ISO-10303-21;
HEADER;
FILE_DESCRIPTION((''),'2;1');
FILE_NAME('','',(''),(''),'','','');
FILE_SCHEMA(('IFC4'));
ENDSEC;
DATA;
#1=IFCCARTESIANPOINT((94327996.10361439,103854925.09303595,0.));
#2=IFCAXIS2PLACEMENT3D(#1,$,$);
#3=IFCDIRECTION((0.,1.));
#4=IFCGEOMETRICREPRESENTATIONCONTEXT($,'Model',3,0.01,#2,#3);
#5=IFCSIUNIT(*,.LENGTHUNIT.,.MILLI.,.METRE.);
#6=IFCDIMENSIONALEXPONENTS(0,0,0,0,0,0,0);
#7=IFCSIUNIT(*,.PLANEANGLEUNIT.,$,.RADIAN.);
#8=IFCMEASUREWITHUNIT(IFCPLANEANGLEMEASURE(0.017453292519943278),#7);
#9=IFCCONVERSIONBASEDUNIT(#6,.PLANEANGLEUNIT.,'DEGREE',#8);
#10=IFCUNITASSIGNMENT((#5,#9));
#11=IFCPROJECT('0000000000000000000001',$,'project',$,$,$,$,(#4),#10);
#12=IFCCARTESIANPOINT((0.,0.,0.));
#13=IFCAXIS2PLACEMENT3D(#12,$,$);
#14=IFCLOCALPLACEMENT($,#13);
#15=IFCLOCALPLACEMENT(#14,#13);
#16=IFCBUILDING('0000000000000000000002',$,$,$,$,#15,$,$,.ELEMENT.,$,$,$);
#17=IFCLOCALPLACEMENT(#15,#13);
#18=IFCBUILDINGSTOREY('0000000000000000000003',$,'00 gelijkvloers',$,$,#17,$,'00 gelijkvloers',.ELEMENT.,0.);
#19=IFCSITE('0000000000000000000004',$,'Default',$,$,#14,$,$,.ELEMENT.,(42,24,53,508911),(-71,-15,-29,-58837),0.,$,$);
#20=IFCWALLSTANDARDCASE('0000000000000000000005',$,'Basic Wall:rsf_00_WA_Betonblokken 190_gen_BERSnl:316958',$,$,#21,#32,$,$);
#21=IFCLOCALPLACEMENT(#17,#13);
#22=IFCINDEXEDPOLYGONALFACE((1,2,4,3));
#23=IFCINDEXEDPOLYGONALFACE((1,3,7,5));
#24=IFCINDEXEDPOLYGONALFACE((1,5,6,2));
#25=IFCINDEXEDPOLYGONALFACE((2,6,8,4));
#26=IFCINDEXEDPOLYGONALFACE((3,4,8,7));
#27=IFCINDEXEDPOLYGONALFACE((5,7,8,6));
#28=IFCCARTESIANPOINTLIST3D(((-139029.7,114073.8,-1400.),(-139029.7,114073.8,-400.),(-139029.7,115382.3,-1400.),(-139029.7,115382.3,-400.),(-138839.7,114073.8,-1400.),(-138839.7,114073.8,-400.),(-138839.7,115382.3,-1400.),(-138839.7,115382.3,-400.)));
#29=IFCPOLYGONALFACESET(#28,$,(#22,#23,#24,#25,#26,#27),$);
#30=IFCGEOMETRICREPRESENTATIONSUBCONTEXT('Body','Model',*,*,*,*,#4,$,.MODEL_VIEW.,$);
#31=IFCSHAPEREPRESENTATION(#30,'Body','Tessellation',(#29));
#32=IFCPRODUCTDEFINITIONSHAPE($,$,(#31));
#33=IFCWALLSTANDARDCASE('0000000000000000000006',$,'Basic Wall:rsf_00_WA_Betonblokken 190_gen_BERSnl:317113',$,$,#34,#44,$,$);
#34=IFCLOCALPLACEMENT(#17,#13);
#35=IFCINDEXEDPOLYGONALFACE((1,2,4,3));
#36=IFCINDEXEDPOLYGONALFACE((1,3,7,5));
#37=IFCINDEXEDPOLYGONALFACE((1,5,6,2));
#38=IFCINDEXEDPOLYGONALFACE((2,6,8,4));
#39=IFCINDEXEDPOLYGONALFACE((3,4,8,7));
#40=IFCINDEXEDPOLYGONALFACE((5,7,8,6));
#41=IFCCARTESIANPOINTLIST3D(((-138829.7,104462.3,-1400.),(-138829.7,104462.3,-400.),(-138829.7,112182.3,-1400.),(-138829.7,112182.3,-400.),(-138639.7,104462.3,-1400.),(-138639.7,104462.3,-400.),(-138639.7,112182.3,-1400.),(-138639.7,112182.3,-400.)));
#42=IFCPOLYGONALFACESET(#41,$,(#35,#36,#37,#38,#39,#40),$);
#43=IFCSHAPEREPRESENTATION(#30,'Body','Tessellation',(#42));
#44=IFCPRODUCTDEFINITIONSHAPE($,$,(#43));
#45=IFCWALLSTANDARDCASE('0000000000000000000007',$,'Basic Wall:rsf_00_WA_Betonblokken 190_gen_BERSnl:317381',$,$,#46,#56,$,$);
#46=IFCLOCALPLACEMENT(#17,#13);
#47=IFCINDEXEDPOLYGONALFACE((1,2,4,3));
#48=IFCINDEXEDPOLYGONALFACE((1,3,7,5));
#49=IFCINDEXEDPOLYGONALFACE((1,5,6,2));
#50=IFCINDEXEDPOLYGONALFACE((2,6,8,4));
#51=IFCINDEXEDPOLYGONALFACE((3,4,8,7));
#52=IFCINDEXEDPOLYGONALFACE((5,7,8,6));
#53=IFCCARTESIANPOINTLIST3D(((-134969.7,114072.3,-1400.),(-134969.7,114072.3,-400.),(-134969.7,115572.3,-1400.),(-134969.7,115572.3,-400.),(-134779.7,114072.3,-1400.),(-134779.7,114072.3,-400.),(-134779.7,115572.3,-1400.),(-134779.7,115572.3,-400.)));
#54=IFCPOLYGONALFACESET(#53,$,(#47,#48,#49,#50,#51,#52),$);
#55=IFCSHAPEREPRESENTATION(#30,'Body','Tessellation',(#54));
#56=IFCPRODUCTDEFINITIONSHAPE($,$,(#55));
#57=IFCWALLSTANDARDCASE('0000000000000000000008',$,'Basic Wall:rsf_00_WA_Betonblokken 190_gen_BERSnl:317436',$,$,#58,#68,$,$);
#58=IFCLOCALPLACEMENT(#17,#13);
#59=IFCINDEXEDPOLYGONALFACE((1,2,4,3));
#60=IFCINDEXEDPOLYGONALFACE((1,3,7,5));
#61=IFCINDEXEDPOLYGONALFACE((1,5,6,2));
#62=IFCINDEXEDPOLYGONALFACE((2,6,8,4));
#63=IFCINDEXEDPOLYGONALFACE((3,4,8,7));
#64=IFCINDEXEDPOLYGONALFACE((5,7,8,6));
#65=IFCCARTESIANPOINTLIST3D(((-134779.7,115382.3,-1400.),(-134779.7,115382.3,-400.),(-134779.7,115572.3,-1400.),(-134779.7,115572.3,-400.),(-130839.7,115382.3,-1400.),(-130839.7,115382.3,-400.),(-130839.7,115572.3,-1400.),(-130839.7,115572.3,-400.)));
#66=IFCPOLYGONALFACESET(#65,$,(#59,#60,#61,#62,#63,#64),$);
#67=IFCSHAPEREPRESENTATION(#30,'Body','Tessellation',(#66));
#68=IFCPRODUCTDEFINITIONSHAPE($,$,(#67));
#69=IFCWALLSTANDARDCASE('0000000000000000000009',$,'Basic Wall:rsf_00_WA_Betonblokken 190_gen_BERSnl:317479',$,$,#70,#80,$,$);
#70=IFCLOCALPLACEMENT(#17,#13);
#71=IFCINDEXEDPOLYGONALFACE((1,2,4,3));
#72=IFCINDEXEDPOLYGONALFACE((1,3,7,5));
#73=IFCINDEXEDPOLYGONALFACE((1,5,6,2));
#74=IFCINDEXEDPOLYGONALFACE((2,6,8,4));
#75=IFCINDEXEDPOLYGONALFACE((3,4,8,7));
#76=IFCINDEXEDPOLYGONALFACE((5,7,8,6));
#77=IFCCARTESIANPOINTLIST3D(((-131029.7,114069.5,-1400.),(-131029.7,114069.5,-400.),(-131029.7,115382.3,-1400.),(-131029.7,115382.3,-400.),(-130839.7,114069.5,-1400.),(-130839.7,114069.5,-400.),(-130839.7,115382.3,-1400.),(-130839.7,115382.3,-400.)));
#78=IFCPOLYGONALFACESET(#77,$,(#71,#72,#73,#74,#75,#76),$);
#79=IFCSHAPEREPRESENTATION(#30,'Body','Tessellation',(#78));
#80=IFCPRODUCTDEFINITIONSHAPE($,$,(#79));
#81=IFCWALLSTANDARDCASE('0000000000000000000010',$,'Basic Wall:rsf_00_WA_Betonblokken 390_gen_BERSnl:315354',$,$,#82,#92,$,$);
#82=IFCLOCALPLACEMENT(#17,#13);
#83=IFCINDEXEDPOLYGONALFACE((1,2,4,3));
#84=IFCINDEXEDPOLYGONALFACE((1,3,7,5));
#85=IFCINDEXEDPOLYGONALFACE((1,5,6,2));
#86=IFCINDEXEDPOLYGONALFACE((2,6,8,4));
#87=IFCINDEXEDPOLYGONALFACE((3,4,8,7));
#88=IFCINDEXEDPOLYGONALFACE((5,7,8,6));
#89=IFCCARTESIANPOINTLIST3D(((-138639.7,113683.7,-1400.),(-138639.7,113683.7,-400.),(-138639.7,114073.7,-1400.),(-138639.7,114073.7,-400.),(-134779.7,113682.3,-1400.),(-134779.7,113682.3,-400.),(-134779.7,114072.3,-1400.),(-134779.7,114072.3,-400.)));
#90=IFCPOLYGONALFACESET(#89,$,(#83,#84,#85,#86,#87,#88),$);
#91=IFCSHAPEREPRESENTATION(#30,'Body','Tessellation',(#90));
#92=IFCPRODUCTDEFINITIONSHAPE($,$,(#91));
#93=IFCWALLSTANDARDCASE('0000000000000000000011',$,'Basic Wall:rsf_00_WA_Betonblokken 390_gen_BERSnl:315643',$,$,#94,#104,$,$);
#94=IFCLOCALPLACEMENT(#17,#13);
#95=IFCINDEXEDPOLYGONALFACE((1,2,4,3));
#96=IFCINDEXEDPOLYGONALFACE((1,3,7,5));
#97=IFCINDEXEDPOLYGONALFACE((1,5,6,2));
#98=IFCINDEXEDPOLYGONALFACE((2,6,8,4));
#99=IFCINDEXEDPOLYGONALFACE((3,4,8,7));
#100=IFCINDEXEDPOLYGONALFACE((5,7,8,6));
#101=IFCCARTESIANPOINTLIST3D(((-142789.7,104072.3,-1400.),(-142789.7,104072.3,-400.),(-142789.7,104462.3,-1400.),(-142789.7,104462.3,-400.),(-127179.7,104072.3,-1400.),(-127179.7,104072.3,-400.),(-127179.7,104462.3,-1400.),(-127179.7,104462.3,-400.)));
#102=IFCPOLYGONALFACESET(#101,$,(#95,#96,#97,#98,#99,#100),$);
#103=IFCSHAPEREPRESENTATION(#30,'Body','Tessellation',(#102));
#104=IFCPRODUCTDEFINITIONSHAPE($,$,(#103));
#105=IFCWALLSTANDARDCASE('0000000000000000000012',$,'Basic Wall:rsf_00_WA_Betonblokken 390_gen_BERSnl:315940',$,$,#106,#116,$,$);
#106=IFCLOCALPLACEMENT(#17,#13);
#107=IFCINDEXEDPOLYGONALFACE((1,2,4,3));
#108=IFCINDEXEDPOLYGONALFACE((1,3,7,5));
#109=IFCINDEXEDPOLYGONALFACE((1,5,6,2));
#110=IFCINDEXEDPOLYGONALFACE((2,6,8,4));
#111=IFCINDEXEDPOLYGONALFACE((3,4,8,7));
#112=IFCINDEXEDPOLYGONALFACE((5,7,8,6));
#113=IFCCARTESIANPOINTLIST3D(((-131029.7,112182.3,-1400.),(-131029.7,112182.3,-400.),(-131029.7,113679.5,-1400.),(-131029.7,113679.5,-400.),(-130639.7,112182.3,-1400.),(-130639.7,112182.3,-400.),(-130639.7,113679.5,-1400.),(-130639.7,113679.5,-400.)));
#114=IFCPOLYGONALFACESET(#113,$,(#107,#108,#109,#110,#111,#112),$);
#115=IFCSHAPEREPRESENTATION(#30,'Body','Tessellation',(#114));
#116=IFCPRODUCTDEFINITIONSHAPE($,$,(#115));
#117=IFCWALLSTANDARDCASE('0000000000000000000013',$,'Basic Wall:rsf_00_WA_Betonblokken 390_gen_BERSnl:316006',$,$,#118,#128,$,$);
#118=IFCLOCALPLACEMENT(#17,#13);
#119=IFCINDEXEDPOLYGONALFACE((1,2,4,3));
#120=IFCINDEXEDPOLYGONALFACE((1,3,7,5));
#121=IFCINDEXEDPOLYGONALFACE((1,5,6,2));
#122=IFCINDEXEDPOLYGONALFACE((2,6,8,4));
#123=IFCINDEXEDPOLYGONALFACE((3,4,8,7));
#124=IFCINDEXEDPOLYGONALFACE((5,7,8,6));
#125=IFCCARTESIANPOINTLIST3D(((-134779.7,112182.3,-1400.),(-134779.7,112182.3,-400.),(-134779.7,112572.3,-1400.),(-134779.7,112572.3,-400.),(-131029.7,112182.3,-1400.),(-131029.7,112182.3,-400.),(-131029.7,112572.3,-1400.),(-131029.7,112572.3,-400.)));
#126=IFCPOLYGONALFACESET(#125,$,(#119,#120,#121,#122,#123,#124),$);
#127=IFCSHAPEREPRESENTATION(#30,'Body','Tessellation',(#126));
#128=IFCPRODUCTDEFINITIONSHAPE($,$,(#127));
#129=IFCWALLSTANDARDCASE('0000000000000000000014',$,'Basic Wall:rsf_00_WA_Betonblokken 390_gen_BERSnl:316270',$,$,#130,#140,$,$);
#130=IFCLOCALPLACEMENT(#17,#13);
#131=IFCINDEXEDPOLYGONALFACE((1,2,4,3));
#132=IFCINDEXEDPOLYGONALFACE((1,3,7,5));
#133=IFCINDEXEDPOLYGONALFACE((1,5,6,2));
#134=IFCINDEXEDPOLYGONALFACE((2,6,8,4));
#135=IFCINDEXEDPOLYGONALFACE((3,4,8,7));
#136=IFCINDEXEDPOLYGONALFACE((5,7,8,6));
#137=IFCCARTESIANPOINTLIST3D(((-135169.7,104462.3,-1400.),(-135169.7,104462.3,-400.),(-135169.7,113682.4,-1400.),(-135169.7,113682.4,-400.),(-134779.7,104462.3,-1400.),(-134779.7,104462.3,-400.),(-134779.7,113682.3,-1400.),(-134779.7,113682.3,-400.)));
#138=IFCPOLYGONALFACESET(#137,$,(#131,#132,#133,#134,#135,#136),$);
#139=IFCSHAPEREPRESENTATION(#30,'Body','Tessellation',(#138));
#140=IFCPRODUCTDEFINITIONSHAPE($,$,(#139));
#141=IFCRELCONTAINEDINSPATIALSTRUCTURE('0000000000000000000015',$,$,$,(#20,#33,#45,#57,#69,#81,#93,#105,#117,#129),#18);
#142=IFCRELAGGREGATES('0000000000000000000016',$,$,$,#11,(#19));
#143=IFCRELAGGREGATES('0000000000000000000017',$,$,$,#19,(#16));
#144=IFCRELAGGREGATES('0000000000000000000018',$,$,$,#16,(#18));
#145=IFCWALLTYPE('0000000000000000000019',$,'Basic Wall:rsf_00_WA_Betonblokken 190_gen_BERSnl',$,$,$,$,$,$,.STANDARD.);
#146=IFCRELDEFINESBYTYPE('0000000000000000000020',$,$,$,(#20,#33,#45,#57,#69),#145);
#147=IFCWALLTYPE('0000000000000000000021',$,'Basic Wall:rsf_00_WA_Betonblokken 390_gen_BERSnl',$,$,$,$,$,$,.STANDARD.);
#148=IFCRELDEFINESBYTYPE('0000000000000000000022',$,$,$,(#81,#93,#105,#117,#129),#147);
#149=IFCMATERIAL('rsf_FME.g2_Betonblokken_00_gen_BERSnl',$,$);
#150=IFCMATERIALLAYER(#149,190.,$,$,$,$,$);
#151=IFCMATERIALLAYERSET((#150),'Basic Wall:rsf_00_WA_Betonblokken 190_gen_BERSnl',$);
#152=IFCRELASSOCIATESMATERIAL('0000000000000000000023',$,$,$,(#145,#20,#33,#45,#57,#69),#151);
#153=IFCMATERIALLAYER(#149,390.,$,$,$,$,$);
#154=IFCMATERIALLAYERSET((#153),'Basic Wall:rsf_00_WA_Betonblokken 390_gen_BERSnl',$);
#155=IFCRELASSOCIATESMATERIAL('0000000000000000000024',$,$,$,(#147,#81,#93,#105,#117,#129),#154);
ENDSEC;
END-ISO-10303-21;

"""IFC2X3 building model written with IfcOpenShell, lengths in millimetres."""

from ifc_helpers import new_model, entity, si_unit, converted_unit, direction, frame, frame_2d, origin, place, context, subcontext, project, spatial, polyline, rectangle, outline, extrude, clip, bounded_halfspace, material, layer, layer_set, layer_usage, type_object, element, save


model = new_model("IFC2X3")

# Units and contexts
model_context = context("Model", 3, precision=0.01, world=frame((94327996.10361439, 103854925.09303595, 0.0)), true_north=direction((0.0, 1.0)))
body_context = subcontext(model_context, "Body", "Model", "MODEL_VIEW")
ifc_project = project(units=[si_unit("LENGTHUNIT", "METRE", prefix="MILLI"), converted_unit("PLANEANGLEUNIT", "DEGREE", entity("IfcPlaneAngleMeasure", 0.017453292519943278), si_unit("PLANEANGLEUNIT", "RADIAN"), dimensions=[0, 0, 0, 0, 0, 0, 0])], contexts=[model_context])

# Site, building, storey
site_placement = place(None, origin())
site = spatial("IfcSite", under=ifc_project, at=site_placement, Name="Default", CompositionType="ELEMENT", RefLatitude=(42, 24, 53, 508911), RefLongitude=(-71, -15, -29, -58837), RefElevation=0.0)
building_placement = place(site_placement, origin())
building = spatial("IfcBuilding", under=site, at=building_placement, CompositionType="ELEMENT")
storey_placement = place(building_placement, origin())
storey = spatial("IfcBuildingStorey", under=building, at=storey_placement, Name="00 gelijkvloers", LongName="00 gelijkvloers", CompositionType="ELEMENT", Elevation=0.0)

# Walls
ifc_material_1 = material(Name="rsf_FME.g2_Betonblokken_00_gen_BERSnl")
ifc_layer_1 = layer(ifc_material_1, 190.0)
ifc_layer_set_1 = layer_set([ifc_layer_1], Name="Basic Wall:rsf_00_WA_Betonblokken 190_gen_BERSnl")
ifc_layer_usage_1 = layer_usage(ifc_layer_set_1, "AXIS2", "NEGATIVE", 95.0)
wall_type_1 = type_object("IfcWallType", Name="Basic Wall:rsf_00_WA_Betonblokken 190_gen_BERSnl", PredefinedType="STANDARD", material=ifc_layer_set_1)
wall_1_placement = place(storey_placement, frame((-138934.7, 115382.3, -1400.0), z_axis=(0.0, 0.0, 1.0), x_axis=(0.0, -1.0, 0.0)))
element("IfcWallStandardCase", 1, at=wall_1_placement, inside=storey, type_object=wall_type_1, material=ifc_layer_usage_1, Name="Basic Wall:rsf_00_WA_Betonblokken 190_gen_BERSnl:316958", context=body_context, shape_type="Clipping", body=[
    clip(extrude(outline(polyline([(1308.5, -95.0), (1308.6, 95.0), (0.0, 95.0), (0.0, -95.0), (1308.5, -95.0)])), origin(), (0.0, 0.0, 1.0), 1000.0), bounded_halfspace(frame((0.0, -95.0, 1000.0), z_axis=(0.0, 0.0, -1.0), x_axis=(-1.0, 0.0, 0.0)), True, frame((0.0, -95.0, 1000.0)), polyline([(0.0, 0.0), (1308.5, 0.0), (1308.6, 190.0), (0.0, 190.0), (0.0, 0.0)]))),
])
ifc_layer_usage_2 = layer_usage(ifc_layer_set_1, "AXIS2", "NEGATIVE", 95.0)
wall_2_placement = place(storey_placement, frame((-138734.7, 112182.3, -1400.0), z_axis=(0.0, 0.0, 1.0), x_axis=(0.0, -1.0, 0.0)))
element("IfcWallStandardCase", 2, at=wall_2_placement, inside=storey, type_object=wall_type_1, material=ifc_layer_usage_2, Name="Basic Wall:rsf_00_WA_Betonblokken 190_gen_BERSnl:317113", context=body_context, shape_type="Clipping", body=[
    clip(extrude(rectangle(XDim=7720.0, YDim=190.0, at=frame_2d((3860.0, 0.0), x_axis=(-1.0, 0.0))), origin(), (0.0, 0.0, 1.0), 1000.0), bounded_halfspace(frame((0.0, -95.0, 1000.0), z_axis=(0.0, 0.0, -1.0), x_axis=(-1.0, 0.0, 0.0)), True, frame((0.0, -95.0, 1000.0)), polyline([(0.0, 0.0), (7720.0, 0.0), (7720.0, 190.0), (0.0, 190.0), (0.0, 0.0)]))),
])
ifc_layer_usage_3 = layer_usage(ifc_layer_set_1, "AXIS2", "POSITIVE", -95.0)
wall_3_placement = place(storey_placement, frame((-134874.7, 114072.3, -1400.0), z_axis=(0.0, 0.0, 1.0), x_axis=(0.0, 1.0, 0.0)))
element("IfcWallStandardCase", 3, at=wall_3_placement, inside=storey, type_object=wall_type_1, material=ifc_layer_usage_3, Name="Basic Wall:rsf_00_WA_Betonblokken 190_gen_BERSnl:317381", context=body_context, shape_type="Clipping", body=[
    clip(extrude(outline(polyline([(1500.1, -95.0), (1500.1, 95.0), (0.1, 95.0), (0.0, -95.0), (1310.1, -95.0), (1500.1, -95.0)])), origin(), (0.0, 0.0, 1.0), 1000.0), bounded_halfspace(frame((0.0, -95.0, 1000.0), z_axis=(0.0, 0.0, -1.0), x_axis=(1.0, 0.0, 0.0)), True, frame((0.0, -95.0, 1000.0)), polyline([(0.0, 0.0), (1310.1, 0.0), (1500.1, 0.0), (1500.1, 190.0), (0.1, 190.0), (0.0, 0.0)]))),
])
ifc_layer_usage_4 = layer_usage(ifc_layer_set_1, "AXIS2", "POSITIVE", -95.0)
wall_4_placement = place(storey_placement, frame((-134779.7, 115477.3, -1400.0)))
element("IfcWallStandardCase", 4, at=wall_4_placement, inside=storey, type_object=wall_type_1, material=ifc_layer_usage_4, Name="Basic Wall:rsf_00_WA_Betonblokken 190_gen_BERSnl:317436", context=body_context, shape_type="Clipping", body=[
    clip(extrude(rectangle(XDim=3940.0, YDim=190.0, at=frame_2d((1970.0, 0.0), x_axis=(-1.0, 0.0))), origin(), (0.0, 0.0, 1.0), 1000.0), bounded_halfspace(frame((0.0, -95.0, 1000.0), z_axis=(0.0, 0.0, -1.0), x_axis=(0.0, 1.0, 0.0)), True, frame((0.0, -95.0, 1000.0)), polyline([(0.0, 0.0), (3750.0, 0.0), (3940.0, 0.0), (3940.0, 190.0), (0.0, 190.0), (0.0, 0.0)]))),
])
ifc_layer_usage_5 = layer_usage(ifc_layer_set_1, "AXIS2", "POSITIVE", -95.0)
wall_5_placement = place(storey_placement, frame((-130934.7, 115382.3, -1400.0), z_axis=(0.0, 0.0, 1.0), x_axis=(0.0, -1.0, 0.0)))
element("IfcWallStandardCase", 5, at=wall_5_placement, inside=storey, type_object=wall_type_1, material=ifc_layer_usage_5, Name="Basic Wall:rsf_00_WA_Betonblokken 190_gen_BERSnl:317479", context=body_context, shape_type="Clipping", body=[
    clip(extrude(rectangle(XDim=1312.9, YDim=190.0, at=frame_2d((656.4, 0.0), x_axis=(-1.0, 0.0))), origin(), (0.0, 0.0, 1.0), 1000.0), bounded_halfspace(frame((0.0, -95.0, 1000.0), z_axis=(0.0, 0.0, -1.0), x_axis=(-1.0, 0.0, 0.0)), True, frame((0.0, -95.0, 1000.0)), polyline([(0.0, 0.0), (1312.9, 0.0), (1312.9, 190.0), (0.0, 190.0), (0.0, 0.0)]))),
])
ifc_layer_2 = layer(ifc_material_1, 390.0)
ifc_layer_set_2 = layer_set([ifc_layer_2], Name="Basic Wall:rsf_00_WA_Betonblokken 390_gen_BERSnl")
wall_type_2 = type_object("IfcWallType", Name="Basic Wall:rsf_00_WA_Betonblokken 390_gen_BERSnl", PredefinedType="STANDARD", material=ifc_layer_set_2)
ifc_layer_usage_6 = layer_usage(ifc_layer_set_2, "AXIS2", "NEGATIVE", 195.0)
wall_6_placement = place(storey_placement, frame((-138639.8, 113878.7, -1400.0), z_axis=(0.0, 0.0, 1.0), x_axis=(1.0, -0.000369, 0.0)))
element("IfcWallStandardCase", 6, at=wall_6_placement, inside=storey, type_object=wall_type_2, material=ifc_layer_usage_6, Name="Basic Wall:rsf_00_WA_Betonblokken 390_gen_BERSnl:315354", context=body_context, shape_type="Clipping", body=[
    clip(extrude(outline(polyline([(3860.1, -195.0), (3860.0, 195.0), (3670.0, 195.0), (0.0, 195.0), (0.1, -195.0), (3470.1, -195.0), (3860.1, -195.0)])), origin(), (0.0, 0.0, 1.0), 1000.0), bounded_halfspace(frame((0.1, -195.0, 1000.0), z_axis=(0.0, 0.0, -1.0), x_axis=(-0.000369, 1.0, 0.0)), True, frame((0.1, -195.0, 1000.0)), polyline([(0.0, 0.0), (3470.0, 0.0), (3860.0, 0.0), (3859.9, 390.0), (3669.9, 390.0), (-0.1, 390.0), (0.0, 0.0)]))),
])
ifc_layer_usage_7 = layer_usage(ifc_layer_set_2, "AXIS2", "POSITIVE", -195.0)
wall_7_placement = place(storey_placement, frame((-142789.7, 104267.3, -1400.0)))
element("IfcWallStandardCase", 7, at=wall_7_placement, inside=storey, type_object=wall_type_2, material=ifc_layer_usage_7, Name="Basic Wall:rsf_00_WA_Betonblokken 390_gen_BERSnl:315643", context=body_context, shape_type="Clipping", body=[
    clip(extrude(rectangle(XDim=15610.0, YDim=390.0, at=frame_2d((7805.0, 0.0), x_axis=(-1.0, 0.0))), origin(), (0.0, 0.0, 1.0), 1000.0), bounded_halfspace(frame((0.0, -195.0, 1000.0), z_axis=(0.0, 0.0, -1.0), x_axis=(0.0, 1.0, 0.0)), True, frame((0.0, -195.0, 1000.0)), polyline([(0.0, 0.0), (15610.0, 0.0), (15610.0, 390.0), (12150.0, 390.0), (11960.0, 390.0), (8010.0, 390.0), (7620.0, 390.0), (4150.0, 390.0), (3960.0, 390.0), (0.0, 390.0), (0.0, 0.0)]))),
])
ifc_layer_usage_8 = layer_usage(ifc_layer_set_2, "AXIS2", "NEGATIVE", 195.0)
wall_8_placement = place(storey_placement, frame((-130834.7, 113679.5, -1400.0), z_axis=(0.0, 0.0, 1.0), x_axis=(0.0, -1.0, 0.0)))
element("IfcWallStandardCase", 8, at=wall_8_placement, inside=storey, type_object=wall_type_2, material=ifc_layer_usage_8, Name="Basic Wall:rsf_00_WA_Betonblokken 390_gen_BERSnl:315940", context=body_context, shape_type="Clipping", body=[
    clip(extrude(rectangle(XDim=1497.1, YDim=390.0, at=frame_2d((748.6, 0.0), x_axis=(-1.0, 0.0))), origin(), (0.0, 0.0, 1.0), 1000.0), bounded_halfspace(frame((0.0, -195.0, 1000.0), z_axis=(0.0, 0.0, -1.0), x_axis=(-1.0, 0.0, 0.0)), True, frame((0.0, -195.0, 1000.0)), polyline([(0.0, 0.0), (1107.1, 0.0), (1497.1, 0.0), (1497.1, 200.0), (1497.1, 390.0), (0.0, 390.0), (0.0, 0.0)]))),
])
ifc_layer_usage_9 = layer_usage(ifc_layer_set_2, "AXIS2", "NEGATIVE", 195.0)
wall_9_placement = place(storey_placement, frame((-131029.7, 112377.3, -1400.0), z_axis=(0.0, 0.0, 1.0), x_axis=(-1.0, 0.0, 0.0)))
element("IfcWallStandardCase", 9, at=wall_9_placement, inside=storey, type_object=wall_type_2, material=ifc_layer_usage_9, Name="Basic Wall:rsf_00_WA_Betonblokken 390_gen_BERSnl:316006", context=body_context, shape_type="Clipping", body=[
    clip(extrude(rectangle(XDim=3750.0, YDim=390.0, at=frame_2d((1875.0, 0.0), x_axis=(-1.0, 0.0))), origin(), (0.0, 0.0, 1.0), 1000.0), bounded_halfspace(frame((0.0, -195.0, 1000.0), z_axis=(0.0, 0.0, -1.0), x_axis=(0.0, -1.0, 0.0)), True, frame((0.0, -195.0, 1000.0)), polyline([(0.0, 0.0), (3750.0, 0.0), (3750.0, 390.0), (0.0, 390.0), (0.0, 0.0)]))),
])
ifc_layer_usage_10 = layer_usage(ifc_layer_set_2, "AXIS2", "POSITIVE", -195.0)
wall_10_placement = place(storey_placement, frame((-134974.7, 113682.4, -1400.0), z_axis=(0.0, 0.0, 1.0), x_axis=(0.0, -1.0, 0.0)))
element("IfcWallStandardCase", 10, at=wall_10_placement, inside=storey, type_object=wall_type_2, material=ifc_layer_usage_10, Name="Basic Wall:rsf_00_WA_Betonblokken 390_gen_BERSnl:316270", context=body_context, shape_type="Clipping", body=[
    clip(extrude(outline(polyline([(9220.1, -195.0), (9220.1, 195.0), (1500.1, 195.0), (1110.1, 195.0), (0.1, 195.0), (0.0, -195.0), (9220.1, -195.0)])), origin(), (0.0, 0.0, 1.0), 1000.0), bounded_halfspace(frame((0.0, -195.0, 1000.0), z_axis=(0.0, 0.0, -1.0), x_axis=(-1.0, 0.0, 0.0)), True, frame((0.0, -195.0, 1000.0)), polyline([(0.0, 0.0), (9220.1, 0.0), (9220.1, 390.0), (1500.1, 390.0), (1110.1, 390.0), (0.1, 390.0), (0.0, 0.0)]))),
])

save(model, "model.ifc")
